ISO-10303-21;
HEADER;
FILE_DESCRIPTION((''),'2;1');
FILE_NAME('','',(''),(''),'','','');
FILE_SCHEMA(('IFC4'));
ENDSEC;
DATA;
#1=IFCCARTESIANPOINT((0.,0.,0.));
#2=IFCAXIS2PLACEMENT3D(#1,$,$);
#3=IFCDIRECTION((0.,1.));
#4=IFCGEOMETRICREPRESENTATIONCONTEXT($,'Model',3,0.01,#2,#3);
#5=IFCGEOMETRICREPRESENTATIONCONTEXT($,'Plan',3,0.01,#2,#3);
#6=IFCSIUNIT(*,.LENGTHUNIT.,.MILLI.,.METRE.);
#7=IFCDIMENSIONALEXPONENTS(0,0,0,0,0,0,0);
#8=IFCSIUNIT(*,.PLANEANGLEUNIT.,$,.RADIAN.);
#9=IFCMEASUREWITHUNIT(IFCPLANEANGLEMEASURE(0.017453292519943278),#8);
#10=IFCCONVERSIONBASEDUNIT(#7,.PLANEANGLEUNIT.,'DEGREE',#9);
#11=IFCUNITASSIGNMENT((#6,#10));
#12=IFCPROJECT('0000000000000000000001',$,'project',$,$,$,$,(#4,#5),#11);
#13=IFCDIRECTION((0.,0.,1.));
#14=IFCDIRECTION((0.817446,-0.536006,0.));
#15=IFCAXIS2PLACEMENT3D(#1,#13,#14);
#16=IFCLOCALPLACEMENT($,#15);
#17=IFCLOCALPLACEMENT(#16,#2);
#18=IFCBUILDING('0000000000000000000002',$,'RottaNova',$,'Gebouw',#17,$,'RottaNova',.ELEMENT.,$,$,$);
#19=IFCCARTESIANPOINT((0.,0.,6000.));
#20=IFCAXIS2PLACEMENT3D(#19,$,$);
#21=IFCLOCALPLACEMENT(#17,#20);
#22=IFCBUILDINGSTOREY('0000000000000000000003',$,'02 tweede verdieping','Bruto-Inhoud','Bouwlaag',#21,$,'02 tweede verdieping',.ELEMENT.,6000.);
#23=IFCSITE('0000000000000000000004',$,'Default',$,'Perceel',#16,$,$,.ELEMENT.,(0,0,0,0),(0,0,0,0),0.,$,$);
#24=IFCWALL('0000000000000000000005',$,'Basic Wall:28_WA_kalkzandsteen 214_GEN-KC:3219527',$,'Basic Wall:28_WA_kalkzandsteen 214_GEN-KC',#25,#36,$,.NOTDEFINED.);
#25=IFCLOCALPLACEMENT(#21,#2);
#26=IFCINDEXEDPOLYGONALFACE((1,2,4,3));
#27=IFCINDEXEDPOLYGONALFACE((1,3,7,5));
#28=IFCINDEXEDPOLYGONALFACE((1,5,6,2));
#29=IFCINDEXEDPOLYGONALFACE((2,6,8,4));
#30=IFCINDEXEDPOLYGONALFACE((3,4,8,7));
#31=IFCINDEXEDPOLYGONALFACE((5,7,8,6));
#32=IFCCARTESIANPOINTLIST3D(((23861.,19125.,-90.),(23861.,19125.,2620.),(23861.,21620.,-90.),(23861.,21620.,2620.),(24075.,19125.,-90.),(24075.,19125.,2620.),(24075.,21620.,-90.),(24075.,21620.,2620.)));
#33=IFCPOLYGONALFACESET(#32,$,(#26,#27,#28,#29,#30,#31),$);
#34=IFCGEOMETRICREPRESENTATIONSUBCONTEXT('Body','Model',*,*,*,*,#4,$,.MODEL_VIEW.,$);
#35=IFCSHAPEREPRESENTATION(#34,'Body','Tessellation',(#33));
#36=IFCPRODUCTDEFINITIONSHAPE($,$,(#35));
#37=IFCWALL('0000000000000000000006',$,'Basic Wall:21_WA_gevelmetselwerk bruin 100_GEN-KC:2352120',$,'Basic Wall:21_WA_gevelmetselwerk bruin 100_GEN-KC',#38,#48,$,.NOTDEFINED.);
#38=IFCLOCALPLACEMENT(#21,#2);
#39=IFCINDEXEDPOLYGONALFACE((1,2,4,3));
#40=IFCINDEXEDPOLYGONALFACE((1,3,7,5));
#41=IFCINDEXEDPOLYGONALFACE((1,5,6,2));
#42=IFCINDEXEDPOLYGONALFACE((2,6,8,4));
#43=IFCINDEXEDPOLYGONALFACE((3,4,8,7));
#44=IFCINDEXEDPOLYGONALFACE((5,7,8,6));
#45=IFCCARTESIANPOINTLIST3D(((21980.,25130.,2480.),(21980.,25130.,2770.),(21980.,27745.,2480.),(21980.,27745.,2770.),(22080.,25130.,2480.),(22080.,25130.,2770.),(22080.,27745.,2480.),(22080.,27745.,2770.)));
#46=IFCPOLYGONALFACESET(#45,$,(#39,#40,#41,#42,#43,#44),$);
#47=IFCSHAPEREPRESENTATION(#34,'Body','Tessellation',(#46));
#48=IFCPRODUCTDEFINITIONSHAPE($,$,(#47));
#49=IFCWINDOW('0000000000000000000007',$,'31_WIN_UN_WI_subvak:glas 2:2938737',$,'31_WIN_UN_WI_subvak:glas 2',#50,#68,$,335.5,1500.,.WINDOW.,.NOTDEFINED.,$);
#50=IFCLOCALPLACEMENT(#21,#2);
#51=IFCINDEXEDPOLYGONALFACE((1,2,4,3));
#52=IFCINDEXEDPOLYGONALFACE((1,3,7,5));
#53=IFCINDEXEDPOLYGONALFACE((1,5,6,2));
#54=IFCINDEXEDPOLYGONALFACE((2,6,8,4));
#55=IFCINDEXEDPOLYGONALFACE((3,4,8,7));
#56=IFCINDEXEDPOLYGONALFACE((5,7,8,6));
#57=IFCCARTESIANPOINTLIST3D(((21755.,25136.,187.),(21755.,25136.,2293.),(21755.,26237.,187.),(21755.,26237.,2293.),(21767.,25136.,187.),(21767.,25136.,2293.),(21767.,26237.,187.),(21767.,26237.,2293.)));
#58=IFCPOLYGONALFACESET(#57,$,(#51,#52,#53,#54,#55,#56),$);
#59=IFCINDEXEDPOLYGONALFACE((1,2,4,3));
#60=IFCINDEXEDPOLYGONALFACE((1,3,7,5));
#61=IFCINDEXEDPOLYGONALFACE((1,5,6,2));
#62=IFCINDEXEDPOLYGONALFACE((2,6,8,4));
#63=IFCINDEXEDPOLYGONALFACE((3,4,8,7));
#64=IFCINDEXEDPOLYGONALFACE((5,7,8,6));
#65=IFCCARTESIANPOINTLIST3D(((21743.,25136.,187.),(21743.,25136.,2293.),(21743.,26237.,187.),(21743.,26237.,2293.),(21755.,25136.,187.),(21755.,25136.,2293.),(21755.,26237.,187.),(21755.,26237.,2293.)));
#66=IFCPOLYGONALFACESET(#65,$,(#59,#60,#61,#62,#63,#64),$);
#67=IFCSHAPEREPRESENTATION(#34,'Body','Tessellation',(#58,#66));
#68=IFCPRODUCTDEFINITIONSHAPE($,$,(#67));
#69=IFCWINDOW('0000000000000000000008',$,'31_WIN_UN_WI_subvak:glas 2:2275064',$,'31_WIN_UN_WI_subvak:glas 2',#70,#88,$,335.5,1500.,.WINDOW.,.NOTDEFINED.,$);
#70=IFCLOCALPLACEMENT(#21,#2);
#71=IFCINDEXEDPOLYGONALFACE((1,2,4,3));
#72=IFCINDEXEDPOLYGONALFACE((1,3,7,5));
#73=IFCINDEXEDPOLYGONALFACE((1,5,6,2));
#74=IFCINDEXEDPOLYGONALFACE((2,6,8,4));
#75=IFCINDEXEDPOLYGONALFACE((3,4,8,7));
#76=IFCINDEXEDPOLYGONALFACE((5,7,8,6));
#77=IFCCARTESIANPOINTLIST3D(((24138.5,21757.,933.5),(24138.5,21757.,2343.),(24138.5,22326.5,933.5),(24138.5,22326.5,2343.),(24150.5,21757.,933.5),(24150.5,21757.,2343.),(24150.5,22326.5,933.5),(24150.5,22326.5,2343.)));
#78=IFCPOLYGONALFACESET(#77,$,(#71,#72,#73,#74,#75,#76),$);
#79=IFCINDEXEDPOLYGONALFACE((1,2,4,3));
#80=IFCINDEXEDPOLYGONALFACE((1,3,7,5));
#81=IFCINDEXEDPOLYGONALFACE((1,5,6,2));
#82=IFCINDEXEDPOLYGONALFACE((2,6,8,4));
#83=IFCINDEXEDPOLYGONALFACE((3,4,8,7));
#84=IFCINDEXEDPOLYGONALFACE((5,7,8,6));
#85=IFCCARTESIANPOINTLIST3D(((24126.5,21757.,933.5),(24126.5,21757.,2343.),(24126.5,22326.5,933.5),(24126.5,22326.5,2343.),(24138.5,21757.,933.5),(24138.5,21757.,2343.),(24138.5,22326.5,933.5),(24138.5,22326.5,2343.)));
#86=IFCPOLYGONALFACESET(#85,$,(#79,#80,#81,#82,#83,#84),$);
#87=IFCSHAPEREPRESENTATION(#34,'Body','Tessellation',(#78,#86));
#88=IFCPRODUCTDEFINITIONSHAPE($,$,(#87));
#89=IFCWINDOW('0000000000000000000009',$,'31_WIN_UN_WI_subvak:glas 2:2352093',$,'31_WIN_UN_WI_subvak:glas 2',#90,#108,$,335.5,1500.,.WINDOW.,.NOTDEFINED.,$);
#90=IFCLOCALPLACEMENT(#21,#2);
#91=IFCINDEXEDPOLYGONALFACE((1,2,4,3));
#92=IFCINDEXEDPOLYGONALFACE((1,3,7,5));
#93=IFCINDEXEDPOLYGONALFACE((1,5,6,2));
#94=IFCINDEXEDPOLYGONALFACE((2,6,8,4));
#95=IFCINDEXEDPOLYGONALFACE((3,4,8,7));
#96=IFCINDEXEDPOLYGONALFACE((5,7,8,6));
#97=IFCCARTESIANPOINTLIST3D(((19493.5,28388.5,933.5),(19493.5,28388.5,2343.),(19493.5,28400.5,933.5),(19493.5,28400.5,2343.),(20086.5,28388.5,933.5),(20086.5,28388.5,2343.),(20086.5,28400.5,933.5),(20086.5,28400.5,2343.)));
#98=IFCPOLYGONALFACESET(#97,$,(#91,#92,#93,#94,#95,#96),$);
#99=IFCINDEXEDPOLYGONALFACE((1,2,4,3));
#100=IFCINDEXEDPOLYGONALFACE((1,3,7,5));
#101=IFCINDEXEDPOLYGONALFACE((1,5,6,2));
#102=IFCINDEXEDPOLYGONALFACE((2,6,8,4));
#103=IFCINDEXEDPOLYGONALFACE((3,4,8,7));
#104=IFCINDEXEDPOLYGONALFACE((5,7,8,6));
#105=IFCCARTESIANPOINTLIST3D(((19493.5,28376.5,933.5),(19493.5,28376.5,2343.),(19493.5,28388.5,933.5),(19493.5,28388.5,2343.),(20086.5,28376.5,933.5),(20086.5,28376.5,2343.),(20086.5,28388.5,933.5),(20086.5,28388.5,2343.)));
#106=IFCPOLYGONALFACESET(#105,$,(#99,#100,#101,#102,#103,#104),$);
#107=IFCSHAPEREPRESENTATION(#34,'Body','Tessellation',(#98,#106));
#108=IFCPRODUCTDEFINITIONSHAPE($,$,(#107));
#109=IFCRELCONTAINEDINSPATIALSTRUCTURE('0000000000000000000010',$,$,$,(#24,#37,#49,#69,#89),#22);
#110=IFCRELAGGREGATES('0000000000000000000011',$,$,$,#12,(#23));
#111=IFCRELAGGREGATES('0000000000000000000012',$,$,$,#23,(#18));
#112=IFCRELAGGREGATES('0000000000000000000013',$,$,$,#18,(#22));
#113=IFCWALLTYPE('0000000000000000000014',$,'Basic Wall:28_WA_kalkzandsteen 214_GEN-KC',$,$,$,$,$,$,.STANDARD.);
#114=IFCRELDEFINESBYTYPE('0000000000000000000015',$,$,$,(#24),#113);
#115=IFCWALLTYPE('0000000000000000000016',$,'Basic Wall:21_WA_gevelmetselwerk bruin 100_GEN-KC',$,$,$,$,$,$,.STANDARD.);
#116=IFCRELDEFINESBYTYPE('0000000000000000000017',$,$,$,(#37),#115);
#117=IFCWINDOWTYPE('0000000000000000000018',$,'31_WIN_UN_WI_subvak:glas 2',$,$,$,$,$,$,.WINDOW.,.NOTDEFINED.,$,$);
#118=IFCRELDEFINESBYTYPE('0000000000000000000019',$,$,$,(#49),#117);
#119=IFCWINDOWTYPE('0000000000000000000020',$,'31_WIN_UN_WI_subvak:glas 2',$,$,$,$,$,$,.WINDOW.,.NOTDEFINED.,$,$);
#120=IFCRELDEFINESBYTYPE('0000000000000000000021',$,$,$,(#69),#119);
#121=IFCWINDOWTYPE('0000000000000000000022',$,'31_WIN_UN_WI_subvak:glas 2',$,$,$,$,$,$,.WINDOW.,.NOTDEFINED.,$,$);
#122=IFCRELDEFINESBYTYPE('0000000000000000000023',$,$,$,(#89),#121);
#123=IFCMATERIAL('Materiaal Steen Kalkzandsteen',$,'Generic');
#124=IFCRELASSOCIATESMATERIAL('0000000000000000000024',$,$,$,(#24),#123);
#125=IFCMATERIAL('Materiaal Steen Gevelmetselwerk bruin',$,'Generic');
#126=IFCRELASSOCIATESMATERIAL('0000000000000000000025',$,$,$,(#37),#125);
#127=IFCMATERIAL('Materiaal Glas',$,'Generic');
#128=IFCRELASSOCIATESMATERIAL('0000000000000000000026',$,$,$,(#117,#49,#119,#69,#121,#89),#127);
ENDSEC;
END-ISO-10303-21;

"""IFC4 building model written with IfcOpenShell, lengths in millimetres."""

from ifc_helpers import new_model, entity, si_unit, converted_unit, direction, frame, origin, place, context, subcontext, project, spatial, indexed_curve, outline, extrude, source, transform, mapped, material, type_object, type_shapes, element, save


model = new_model("IFC4")

# Units and contexts
model_context = context("Model", 3, precision=0.01, world=origin(), true_north=direction((0.0, 1.0)))
plan_context = context("Plan", 3, precision=0.01, world=origin(), true_north=direction((0.0, 1.0)))
body_context = subcontext(model_context, "Body", "Model", "MODEL_VIEW")
ifc_project = project(units=[si_unit("LENGTHUNIT", "METRE", prefix="MILLI"), converted_unit("PLANEANGLEUNIT", "DEGREE", entity("IfcPlaneAngleMeasure", 0.017453292519943278), si_unit("PLANEANGLEUNIT", "RADIAN"), dimensions=[0, 0, 0, 0, 0, 0, 0])], contexts=[model_context, plan_context])

# Site, building, storey
site_placement = place(None, frame((0.0, 0.0, 0.0), z_axis=(0.0, 0.0, 1.0), x_axis=(0.817446, -0.536006, 0.0)))
site = spatial("IfcSite", under=ifc_project, at=site_placement, Name="Default", ObjectType="Perceel", CompositionType="ELEMENT", RefLatitude=(0, 0, 0, 0), RefLongitude=(0, 0, 0, 0), RefElevation=0.0)
building_placement = place(site_placement, origin())
building = spatial("IfcBuilding", under=site, at=building_placement, Name="RottaNova", ObjectType="Gebouw", LongName="RottaNova", CompositionType="ELEMENT")
storey_placement = place(building_placement, frame((0.0, 0.0, 6000.0)))
storey = spatial("IfcBuildingStorey", under=building, at=storey_placement, Name="02 tweede verdieping", Description="Bruto-Inhoud", ObjectType="Bouwlaag", LongName="02 tweede verdieping", CompositionType="ELEMENT", Elevation=6000.0)

# Shared definitions
ifc_material_1 = material(Name="Materiaal Glas", Category="Generic")

# Walls
ifc_material_2 = material(Name="Materiaal Steen Kalkzandsteen", Category="Generic")
wall_type_1 = type_object("IfcWallType", Name="Basic Wall:28_WA_kalkzandsteen 214_GEN-KC", PredefinedType="STANDARD")
wall_1_placement = place(storey_placement, frame((23968.0, 21620.0, -90.0), z_axis=(0.0, 0.0, 1.0), x_axis=(0.0, -1.0, 0.0)))
element("IfcWall", 1, at=wall_1_placement, inside=storey, type_object=wall_type_1, material=ifc_material_2, Name="Basic Wall:28_WA_kalkzandsteen 214_GEN-KC:3219527", ObjectType="Basic Wall:28_WA_kalkzandsteen 214_GEN-KC", PredefinedType="NOTDEFINED", context=body_context, shape_type="SweptSolid", body=[
    extrude(outline(indexed_curve([(2495.0, 107.0), (0.0, 107.0), (0.0, -107.0), (2495.0, -107.0), (2495.0, 107.0)], self_intersect=False)), origin(), (0.0, 0.0, 1.0), 2710.0),
])
ifc_material_3 = material(Name="Materiaal Steen Gevelmetselwerk bruin", Category="Generic")
wall_type_2 = type_object("IfcWallType", Name="Basic Wall:21_WA_gevelmetselwerk bruin 100_GEN-KC", PredefinedType="STANDARD")
wall_2_placement = place(storey_placement, frame((22030.0, 25130.0, 2480.0), z_axis=(0.0, 0.0, 1.0), x_axis=(0.0, 1.0, 0.0)))
element("IfcWall", 2, at=wall_2_placement, inside=storey, type_object=wall_type_2, material=ifc_material_3, Name="Basic Wall:21_WA_gevelmetselwerk bruin 100_GEN-KC:2352120", ObjectType="Basic Wall:21_WA_gevelmetselwerk bruin 100_GEN-KC", PredefinedType="NOTDEFINED", context=body_context, shape_type="SweptSolid", body=[
    extrude(outline(indexed_curve([(2615.0, 50.0), (0.0, 50.0), (0.0, -50.0), (2615.0, -50.0), (2615.0, 50.0)], self_intersect=False)), origin(), (0.0, 0.0, 1.0), 290.0),
])

# Windows
window_type_1 = type_object("IfcWindowType", Name="31_WIN_UN_WI_subvak:glas 2", PartitioningType="NOTDEFINED", PredefinedType="WINDOW", material=ifc_material_1)
shared_shape_1 = source(origin(), body_context, "Body", "SweptSolid", [
    extrude(outline(indexed_curve([(-6.0, -550.5), (6.0, -550.5), (6.0, 550.5), (-6.0, 550.5), (-6.0, -550.5)], self_intersect=False)), frame((0.0, 6.0, 0.0), z_axis=(0.0, 0.0, 1.0), x_axis=(0.0, -1.0, 0.0)), (0.0, 0.0, 1.0), 2106.0),
    extrude(outline(indexed_curve([(-6.0, -550.5), (6.0, -550.5), (6.0, 550.5), (-6.0, 550.5), (-6.0, -550.5)], self_intersect=False)), frame((0.0, -6.0, 0.0), z_axis=(0.0, 0.0, 1.0), x_axis=(0.0, -1.0, 0.0)), (0.0, 0.0, 1.0), 2106.0),
])
type_shapes(window_type_1, [shared_shape_1])
window_1_placement = place(storey_placement, frame((21755.0, 25686.5, 187.0), z_axis=(0.0, 0.0, 1.0), x_axis=(0.0, -1.0, 0.0)))
element("IfcWindow", 3, at=window_1_placement, inside=storey, type_object=window_type_1, material=ifc_material_1, Name="31_WIN_UN_WI_subvak:glas 2:2938737", ObjectType="31_WIN_UN_WI_subvak:glas 2", OverallHeight=335.5, OverallWidth=1500.0, PartitioningType="NOTDEFINED", PredefinedType="WINDOW", context=body_context, shape_type="MappedRepresentation", body=[
    mapped(shared_shape_1, transform((0.0, 0.0, 0.0), scale=1.0)),
])
window_type_2 = type_object("IfcWindowType", Name="31_WIN_UN_WI_subvak:glas 2", PartitioningType="NOTDEFINED", PredefinedType="WINDOW", material=ifc_material_1)
shared_shape_2 = source(origin(), body_context, "Body", "SweptSolid", [
    extrude(outline(indexed_curve([(-6.0, -284.7), (6.0, -284.7), (6.0, 284.7), (-6.0, 284.7), (-6.0, -284.7)], self_intersect=False)), frame((0.0, 6.0, 0.0), z_axis=(0.0, 0.0, 1.0), x_axis=(0.0, -1.0, 0.0)), (0.0, 0.0, 1.0), 1409.5),
    extrude(outline(indexed_curve([(-6.0, -284.8), (6.0, -284.8), (6.0, 284.8), (-6.0, 284.8), (-6.0, -284.8)], self_intersect=False)), frame((0.0, -6.0, 0.0), z_axis=(0.0, 0.0, 1.0), x_axis=(0.0, -1.0, 0.0)), (0.0, 0.0, 1.0), 1409.5),
])
type_shapes(window_type_2, [shared_shape_2])
window_2_placement = place(storey_placement, frame((24138.5, 22041.7, 933.5), z_axis=(0.0, 0.0, 1.0), x_axis=(0.0, -1.0, 0.0)))
element("IfcWindow", 4, at=window_2_placement, inside=storey, type_object=window_type_2, material=ifc_material_1, Name="31_WIN_UN_WI_subvak:glas 2:2275064", ObjectType="31_WIN_UN_WI_subvak:glas 2", OverallHeight=335.5, OverallWidth=1500.0, PartitioningType="NOTDEFINED", PredefinedType="WINDOW", context=body_context, shape_type="MappedRepresentation", body=[
    mapped(shared_shape_2, transform((0.0, 0.0, 0.0), scale=1.0)),
])
window_type_3 = type_object("IfcWindowType", Name="31_WIN_UN_WI_subvak:glas 2", PartitioningType="NOTDEFINED", PredefinedType="WINDOW", material=ifc_material_1)
shared_shape_3 = source(origin(), body_context, "Body", "SweptSolid", [
    extrude(outline(indexed_curve([(-6.0, -296.5), (6.0, -296.5), (6.0, 296.5), (-6.0, 296.5), (-6.0, -296.5)], self_intersect=False)), frame((0.0, 6.0, 0.0), z_axis=(0.0, 0.0, 1.0), x_axis=(0.0, -1.0, 0.0)), (0.0, 0.0, 1.0), 1409.5),
    extrude(outline(indexed_curve([(-6.0, -296.5), (6.0, -296.5), (6.0, 296.5), (-6.0, 296.5), (-6.0, -296.5)], self_intersect=False)), frame((0.0, -6.0, 0.0), z_axis=(0.0, 0.0, 1.0), x_axis=(0.0, -1.0, 0.0)), (0.0, 0.0, 1.0), 1409.5),
])
type_shapes(window_type_3, [shared_shape_3])
window_3_placement = place(storey_placement, frame((19790.0, 28388.5, 933.5)))
element("IfcWindow", 5, at=window_3_placement, inside=storey, type_object=window_type_3, material=ifc_material_1, Name="31_WIN_UN_WI_subvak:glas 2:2352093", ObjectType="31_WIN_UN_WI_subvak:glas 2", OverallHeight=335.5, OverallWidth=1500.0, PartitioningType="NOTDEFINED", PredefinedType="WINDOW", context=body_context, shape_type="MappedRepresentation", body=[
    mapped(shared_shape_3, transform((0.0, 0.0, 0.0), scale=1.0)),
])

save(model, "model.ifc")
